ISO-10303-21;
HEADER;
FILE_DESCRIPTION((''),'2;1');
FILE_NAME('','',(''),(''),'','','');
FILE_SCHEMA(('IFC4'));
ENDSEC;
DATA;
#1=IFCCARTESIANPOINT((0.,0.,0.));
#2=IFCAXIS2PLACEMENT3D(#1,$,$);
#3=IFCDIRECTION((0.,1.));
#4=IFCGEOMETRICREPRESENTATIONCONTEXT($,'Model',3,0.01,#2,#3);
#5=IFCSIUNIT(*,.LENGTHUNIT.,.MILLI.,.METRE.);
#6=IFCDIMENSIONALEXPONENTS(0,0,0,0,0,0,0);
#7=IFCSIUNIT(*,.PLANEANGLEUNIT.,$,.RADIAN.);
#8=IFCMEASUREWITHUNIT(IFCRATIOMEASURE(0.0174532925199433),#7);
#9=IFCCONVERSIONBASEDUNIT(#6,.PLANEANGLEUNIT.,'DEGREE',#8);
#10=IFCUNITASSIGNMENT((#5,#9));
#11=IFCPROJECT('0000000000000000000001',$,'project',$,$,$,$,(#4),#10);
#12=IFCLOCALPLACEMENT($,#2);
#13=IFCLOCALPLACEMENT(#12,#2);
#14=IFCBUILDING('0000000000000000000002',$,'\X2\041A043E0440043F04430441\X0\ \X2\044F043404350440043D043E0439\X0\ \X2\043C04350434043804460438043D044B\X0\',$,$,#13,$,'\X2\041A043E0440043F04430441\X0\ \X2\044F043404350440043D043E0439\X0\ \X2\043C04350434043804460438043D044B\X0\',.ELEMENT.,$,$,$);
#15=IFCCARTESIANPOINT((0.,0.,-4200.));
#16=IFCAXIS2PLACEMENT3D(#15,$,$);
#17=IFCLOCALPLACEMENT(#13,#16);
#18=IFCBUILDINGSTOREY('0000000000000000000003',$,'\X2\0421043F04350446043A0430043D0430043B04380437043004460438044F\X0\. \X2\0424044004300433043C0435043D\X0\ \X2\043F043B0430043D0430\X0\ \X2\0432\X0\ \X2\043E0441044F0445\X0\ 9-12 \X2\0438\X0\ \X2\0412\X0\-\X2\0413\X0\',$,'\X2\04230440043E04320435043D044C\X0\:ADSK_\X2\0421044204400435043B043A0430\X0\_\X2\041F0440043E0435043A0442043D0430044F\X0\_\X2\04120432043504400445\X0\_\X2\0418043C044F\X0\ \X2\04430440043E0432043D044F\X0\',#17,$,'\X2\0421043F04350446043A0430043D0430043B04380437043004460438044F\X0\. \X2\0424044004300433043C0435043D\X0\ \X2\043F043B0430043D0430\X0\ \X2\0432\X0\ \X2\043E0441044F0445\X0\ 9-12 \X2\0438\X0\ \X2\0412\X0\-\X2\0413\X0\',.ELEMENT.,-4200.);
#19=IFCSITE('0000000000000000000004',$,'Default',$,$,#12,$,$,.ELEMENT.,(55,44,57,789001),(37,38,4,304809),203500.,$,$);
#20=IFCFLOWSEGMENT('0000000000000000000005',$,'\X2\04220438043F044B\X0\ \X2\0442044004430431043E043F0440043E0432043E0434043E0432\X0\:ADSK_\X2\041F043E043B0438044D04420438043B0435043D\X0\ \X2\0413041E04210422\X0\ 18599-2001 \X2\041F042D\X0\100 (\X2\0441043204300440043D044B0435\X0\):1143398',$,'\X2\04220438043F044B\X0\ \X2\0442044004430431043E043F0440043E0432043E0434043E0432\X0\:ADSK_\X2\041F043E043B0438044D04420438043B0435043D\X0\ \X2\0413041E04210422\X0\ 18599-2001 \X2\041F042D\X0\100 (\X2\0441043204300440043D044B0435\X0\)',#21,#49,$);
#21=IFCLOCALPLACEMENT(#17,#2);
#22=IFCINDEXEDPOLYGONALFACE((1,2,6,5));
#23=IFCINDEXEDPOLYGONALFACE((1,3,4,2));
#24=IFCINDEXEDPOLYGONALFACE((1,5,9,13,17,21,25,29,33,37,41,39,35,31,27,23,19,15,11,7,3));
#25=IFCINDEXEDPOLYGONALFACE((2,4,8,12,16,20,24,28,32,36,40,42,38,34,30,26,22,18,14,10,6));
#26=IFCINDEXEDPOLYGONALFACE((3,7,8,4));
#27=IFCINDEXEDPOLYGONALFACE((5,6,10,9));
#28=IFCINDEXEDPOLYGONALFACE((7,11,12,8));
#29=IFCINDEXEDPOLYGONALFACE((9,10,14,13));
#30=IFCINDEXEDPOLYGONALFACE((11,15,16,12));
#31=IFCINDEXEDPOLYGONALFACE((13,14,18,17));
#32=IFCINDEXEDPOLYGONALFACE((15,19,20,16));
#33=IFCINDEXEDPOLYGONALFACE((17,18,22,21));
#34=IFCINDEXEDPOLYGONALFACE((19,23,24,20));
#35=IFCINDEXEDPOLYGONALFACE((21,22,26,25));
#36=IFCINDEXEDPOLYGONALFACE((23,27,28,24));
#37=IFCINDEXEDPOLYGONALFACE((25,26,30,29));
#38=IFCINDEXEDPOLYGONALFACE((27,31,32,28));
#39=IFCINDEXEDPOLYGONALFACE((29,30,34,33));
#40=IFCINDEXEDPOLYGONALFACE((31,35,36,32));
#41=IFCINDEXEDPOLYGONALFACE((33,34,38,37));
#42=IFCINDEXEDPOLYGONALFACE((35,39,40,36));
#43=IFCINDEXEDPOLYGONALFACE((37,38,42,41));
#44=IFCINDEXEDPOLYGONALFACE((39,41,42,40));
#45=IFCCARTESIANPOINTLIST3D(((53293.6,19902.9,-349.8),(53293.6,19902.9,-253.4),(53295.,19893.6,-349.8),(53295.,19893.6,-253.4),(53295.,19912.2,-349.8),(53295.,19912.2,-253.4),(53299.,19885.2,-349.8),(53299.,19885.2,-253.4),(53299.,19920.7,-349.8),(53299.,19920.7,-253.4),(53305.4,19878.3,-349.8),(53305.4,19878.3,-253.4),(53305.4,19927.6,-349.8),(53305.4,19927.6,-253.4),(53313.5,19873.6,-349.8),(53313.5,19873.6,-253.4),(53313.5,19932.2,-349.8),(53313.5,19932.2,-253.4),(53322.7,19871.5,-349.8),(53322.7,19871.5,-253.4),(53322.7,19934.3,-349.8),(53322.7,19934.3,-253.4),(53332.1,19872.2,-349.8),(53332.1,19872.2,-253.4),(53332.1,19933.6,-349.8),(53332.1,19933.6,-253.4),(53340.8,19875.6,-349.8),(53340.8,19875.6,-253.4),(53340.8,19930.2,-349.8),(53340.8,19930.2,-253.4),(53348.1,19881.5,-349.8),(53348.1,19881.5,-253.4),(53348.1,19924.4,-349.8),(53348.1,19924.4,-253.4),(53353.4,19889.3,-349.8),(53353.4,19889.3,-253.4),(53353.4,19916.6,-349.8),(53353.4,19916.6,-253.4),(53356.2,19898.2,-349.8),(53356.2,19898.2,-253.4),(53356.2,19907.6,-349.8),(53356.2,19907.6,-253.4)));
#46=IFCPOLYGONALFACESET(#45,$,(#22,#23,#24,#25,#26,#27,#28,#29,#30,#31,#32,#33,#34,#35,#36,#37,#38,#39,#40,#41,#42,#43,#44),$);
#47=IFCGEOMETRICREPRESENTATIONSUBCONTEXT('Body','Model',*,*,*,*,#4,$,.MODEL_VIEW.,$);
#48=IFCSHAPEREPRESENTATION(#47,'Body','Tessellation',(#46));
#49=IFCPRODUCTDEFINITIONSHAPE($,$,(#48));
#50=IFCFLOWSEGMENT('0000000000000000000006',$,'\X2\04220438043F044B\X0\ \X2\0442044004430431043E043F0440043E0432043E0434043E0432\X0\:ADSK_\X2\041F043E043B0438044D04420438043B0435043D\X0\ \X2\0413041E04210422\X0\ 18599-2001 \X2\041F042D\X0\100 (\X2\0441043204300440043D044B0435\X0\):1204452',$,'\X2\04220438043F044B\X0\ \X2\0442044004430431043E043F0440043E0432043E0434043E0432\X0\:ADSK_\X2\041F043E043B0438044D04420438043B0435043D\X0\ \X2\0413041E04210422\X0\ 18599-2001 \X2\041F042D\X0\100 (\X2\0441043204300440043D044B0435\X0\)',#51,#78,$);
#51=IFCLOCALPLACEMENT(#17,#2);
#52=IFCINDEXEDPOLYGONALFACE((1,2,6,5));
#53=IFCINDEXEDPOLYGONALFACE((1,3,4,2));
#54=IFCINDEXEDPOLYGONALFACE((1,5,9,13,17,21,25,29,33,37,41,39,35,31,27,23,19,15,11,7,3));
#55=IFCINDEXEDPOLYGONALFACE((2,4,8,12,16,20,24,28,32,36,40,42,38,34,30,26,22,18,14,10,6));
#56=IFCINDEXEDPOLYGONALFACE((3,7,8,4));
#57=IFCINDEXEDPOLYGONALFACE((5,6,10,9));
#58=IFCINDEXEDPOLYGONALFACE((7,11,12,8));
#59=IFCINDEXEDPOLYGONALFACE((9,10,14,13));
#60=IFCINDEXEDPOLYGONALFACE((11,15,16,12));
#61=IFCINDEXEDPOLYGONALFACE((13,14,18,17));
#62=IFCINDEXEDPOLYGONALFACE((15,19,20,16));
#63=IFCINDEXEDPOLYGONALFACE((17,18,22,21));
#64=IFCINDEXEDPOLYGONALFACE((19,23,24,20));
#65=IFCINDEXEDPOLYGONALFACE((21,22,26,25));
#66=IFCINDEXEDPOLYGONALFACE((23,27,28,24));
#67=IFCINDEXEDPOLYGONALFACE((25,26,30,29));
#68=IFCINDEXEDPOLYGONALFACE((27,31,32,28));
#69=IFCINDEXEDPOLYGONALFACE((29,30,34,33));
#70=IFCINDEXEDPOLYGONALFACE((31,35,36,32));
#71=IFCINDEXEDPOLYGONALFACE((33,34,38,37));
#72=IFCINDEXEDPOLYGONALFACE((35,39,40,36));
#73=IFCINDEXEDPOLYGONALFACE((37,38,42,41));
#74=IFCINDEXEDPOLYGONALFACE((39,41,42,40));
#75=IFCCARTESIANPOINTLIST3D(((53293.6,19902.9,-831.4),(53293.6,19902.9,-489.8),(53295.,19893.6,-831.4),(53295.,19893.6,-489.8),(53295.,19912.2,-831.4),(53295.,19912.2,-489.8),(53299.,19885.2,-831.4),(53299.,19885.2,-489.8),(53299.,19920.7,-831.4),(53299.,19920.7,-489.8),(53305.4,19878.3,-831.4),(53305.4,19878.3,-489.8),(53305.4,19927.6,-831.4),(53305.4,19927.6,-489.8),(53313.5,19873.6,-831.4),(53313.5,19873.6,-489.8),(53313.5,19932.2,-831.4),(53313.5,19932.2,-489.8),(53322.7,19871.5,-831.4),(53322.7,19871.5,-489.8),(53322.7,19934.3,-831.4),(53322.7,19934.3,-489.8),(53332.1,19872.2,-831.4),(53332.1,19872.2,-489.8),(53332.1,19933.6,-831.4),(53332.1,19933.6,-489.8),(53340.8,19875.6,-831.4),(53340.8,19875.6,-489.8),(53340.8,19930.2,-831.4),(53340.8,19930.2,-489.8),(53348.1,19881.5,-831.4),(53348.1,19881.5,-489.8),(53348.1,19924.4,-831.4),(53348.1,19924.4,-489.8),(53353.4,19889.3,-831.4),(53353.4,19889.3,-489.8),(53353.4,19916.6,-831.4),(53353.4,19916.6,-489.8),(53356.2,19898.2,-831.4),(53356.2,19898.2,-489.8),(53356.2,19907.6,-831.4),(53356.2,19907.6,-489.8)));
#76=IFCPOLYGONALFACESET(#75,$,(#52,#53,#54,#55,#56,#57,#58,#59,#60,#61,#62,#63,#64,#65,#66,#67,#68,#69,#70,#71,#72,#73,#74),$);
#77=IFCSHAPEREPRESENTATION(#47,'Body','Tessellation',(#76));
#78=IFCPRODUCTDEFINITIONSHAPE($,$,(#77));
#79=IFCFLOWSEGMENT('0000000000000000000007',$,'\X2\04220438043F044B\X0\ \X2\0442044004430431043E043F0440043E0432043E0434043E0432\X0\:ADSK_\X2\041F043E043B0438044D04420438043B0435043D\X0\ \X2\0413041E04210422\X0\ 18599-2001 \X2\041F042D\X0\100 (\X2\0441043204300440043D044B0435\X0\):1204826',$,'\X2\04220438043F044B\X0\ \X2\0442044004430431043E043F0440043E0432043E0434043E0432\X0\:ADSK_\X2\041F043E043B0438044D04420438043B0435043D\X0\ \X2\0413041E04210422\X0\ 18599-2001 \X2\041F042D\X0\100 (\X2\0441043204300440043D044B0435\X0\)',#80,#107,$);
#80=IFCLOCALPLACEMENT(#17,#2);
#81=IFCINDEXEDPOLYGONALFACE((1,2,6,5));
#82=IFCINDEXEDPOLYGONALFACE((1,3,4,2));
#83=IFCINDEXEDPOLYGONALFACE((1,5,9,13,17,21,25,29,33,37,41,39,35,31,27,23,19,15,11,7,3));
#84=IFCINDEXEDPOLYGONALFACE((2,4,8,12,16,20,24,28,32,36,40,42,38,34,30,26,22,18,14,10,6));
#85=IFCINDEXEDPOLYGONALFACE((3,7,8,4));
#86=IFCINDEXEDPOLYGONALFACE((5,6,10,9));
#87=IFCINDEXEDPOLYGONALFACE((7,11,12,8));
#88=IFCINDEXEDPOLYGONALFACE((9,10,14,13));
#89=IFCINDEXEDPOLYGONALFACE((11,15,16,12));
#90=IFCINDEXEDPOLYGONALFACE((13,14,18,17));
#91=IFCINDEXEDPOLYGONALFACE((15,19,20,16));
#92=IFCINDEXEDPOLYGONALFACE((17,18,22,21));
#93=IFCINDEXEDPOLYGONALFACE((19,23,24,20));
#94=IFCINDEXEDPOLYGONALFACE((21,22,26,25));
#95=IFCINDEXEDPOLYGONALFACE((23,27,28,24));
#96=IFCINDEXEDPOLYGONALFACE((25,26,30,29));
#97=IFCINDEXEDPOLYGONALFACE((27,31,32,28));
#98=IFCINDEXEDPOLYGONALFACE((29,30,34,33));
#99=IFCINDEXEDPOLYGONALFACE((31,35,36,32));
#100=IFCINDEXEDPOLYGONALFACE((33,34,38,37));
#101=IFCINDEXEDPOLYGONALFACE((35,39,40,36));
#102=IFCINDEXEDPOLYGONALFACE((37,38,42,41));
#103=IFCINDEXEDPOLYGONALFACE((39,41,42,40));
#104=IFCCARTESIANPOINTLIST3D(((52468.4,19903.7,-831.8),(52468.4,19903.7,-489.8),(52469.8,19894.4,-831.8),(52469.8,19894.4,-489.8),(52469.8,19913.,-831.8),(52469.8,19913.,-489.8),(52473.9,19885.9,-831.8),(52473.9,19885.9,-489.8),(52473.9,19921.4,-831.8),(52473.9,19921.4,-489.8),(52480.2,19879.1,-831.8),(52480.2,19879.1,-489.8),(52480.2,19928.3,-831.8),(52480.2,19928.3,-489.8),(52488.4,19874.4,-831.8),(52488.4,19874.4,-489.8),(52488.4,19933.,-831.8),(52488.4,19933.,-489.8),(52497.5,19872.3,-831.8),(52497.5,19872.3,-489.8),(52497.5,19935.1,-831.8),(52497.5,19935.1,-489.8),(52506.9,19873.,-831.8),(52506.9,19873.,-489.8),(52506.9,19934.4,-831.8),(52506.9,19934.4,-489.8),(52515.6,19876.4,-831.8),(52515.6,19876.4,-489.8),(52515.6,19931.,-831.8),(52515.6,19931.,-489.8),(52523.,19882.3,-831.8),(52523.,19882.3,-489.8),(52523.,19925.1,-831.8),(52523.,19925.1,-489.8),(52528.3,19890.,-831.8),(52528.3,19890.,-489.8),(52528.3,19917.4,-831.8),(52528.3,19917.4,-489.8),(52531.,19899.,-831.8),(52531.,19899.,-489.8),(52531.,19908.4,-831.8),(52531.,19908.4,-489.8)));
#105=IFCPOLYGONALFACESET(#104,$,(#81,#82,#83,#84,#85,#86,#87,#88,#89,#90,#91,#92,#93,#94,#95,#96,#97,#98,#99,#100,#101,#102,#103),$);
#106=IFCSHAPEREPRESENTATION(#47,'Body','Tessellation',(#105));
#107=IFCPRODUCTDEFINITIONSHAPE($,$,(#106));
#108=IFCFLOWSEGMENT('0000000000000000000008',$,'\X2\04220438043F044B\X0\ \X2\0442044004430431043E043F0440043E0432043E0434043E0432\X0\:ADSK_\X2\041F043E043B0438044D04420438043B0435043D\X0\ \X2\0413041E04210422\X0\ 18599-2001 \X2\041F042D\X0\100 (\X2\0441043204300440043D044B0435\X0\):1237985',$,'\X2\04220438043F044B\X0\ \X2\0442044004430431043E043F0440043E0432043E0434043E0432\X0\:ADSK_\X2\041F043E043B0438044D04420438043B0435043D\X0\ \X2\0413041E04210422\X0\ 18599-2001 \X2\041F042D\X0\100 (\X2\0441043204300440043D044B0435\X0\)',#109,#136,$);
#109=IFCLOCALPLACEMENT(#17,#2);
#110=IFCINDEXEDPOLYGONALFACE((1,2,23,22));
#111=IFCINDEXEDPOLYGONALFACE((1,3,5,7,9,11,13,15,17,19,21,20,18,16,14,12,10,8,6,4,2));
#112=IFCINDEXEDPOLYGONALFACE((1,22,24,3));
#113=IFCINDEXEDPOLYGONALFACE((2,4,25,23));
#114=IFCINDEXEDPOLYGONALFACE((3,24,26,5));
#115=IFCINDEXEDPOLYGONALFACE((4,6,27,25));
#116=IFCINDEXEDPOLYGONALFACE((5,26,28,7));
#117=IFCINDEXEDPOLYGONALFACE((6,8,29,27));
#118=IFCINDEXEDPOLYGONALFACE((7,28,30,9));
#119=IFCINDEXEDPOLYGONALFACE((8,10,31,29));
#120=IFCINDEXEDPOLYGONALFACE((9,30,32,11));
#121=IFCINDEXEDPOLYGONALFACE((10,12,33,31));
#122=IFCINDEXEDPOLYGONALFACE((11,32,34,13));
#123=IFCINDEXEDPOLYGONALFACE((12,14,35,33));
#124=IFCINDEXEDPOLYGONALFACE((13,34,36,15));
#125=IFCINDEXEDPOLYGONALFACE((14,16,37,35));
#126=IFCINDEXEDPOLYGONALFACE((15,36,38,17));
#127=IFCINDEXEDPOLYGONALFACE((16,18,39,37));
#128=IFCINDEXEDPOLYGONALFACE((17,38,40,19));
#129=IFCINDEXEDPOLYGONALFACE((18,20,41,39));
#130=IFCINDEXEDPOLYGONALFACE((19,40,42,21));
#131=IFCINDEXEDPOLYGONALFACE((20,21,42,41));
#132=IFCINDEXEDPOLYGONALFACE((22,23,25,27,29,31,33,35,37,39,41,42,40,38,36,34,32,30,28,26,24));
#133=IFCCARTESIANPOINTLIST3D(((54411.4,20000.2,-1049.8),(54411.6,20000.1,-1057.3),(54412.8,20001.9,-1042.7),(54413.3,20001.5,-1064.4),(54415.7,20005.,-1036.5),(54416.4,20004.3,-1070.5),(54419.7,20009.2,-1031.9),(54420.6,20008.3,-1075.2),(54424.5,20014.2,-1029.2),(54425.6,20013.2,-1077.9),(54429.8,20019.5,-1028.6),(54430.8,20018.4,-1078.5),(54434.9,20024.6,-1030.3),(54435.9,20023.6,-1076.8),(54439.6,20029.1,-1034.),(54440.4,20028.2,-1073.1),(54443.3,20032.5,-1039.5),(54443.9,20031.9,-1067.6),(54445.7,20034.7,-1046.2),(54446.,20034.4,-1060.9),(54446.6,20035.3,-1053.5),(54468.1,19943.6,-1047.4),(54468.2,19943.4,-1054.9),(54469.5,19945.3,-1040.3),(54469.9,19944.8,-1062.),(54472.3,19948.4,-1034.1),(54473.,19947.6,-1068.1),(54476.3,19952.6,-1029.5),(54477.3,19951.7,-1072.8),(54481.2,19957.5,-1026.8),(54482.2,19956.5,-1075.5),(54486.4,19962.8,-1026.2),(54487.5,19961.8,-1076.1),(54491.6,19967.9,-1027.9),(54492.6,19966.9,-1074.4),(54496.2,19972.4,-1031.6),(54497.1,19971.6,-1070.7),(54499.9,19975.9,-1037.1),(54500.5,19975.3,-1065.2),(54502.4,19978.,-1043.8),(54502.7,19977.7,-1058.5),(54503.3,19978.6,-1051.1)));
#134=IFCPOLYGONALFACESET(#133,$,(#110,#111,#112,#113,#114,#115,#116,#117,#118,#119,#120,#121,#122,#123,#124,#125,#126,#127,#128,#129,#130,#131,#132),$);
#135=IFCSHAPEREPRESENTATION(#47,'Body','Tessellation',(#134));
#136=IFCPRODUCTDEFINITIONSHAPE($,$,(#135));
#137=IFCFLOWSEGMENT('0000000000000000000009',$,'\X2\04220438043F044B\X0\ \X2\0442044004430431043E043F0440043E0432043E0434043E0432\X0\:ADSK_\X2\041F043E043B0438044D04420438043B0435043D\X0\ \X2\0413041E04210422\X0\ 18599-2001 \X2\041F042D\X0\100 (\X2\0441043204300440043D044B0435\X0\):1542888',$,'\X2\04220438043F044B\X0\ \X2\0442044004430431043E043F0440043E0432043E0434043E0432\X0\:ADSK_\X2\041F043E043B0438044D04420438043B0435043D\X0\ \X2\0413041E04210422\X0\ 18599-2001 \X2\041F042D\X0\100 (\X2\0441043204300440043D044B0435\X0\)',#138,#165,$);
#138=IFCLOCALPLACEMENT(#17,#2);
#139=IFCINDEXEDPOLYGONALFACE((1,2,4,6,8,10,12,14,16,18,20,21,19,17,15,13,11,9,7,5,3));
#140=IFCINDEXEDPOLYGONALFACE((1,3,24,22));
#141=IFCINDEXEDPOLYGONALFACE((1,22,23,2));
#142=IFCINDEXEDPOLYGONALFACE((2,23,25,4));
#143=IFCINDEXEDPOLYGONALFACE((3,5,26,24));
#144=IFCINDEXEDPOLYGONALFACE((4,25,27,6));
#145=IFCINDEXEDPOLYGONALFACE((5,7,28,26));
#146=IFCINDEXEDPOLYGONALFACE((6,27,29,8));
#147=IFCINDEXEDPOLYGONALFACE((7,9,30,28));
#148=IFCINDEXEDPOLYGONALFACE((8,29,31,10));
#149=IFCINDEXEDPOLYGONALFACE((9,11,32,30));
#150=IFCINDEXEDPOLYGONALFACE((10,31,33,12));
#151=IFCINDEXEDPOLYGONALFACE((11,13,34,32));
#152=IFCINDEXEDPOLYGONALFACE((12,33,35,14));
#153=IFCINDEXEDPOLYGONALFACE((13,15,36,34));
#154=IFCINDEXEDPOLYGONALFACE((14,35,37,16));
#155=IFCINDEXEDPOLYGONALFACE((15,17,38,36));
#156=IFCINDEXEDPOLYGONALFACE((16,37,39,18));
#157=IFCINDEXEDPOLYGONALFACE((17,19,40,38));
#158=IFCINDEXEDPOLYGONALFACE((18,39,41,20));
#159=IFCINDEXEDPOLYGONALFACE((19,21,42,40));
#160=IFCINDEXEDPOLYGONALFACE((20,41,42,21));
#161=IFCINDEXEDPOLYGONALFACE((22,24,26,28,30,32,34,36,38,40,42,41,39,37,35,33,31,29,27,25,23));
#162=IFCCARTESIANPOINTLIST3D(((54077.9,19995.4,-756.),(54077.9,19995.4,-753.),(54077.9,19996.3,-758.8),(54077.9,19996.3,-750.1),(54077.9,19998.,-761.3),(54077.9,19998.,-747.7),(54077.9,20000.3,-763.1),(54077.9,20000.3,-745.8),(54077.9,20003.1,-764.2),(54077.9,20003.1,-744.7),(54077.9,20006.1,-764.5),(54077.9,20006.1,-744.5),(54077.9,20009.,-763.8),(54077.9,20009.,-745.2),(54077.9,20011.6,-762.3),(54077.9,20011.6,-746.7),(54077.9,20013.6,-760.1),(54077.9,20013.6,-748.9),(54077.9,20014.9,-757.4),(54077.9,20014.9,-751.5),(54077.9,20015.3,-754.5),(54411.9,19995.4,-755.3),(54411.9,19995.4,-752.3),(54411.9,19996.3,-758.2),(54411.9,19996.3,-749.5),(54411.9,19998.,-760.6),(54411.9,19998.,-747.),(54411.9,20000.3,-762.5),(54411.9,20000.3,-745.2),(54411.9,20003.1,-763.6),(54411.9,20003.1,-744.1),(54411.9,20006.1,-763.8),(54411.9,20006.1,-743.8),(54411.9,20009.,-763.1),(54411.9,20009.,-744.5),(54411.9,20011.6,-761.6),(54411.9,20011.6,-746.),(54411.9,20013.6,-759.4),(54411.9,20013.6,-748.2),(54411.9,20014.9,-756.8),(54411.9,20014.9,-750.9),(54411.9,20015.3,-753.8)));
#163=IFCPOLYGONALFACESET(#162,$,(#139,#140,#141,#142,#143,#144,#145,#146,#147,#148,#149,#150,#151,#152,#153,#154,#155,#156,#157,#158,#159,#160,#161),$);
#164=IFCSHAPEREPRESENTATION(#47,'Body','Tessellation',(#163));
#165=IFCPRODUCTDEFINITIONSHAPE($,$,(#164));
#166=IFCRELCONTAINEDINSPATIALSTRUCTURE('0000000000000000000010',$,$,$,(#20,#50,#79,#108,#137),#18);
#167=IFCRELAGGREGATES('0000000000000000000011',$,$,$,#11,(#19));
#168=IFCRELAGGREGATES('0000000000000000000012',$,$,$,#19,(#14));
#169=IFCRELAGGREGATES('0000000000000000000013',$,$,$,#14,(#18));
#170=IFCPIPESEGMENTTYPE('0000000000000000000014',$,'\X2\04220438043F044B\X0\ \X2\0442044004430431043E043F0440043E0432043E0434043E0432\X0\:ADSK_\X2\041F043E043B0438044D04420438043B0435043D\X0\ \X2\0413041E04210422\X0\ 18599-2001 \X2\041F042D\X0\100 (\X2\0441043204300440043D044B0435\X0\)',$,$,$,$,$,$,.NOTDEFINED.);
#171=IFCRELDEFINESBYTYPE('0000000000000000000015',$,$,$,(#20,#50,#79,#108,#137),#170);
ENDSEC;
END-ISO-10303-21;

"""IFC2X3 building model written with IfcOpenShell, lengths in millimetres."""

from ifc_helpers import new_model, entity, si_unit, converted_unit, direction, frame, frame_2d, origin, origin_2d_with_axis, place, context, subcontext, project, spatial, circle, extrude, type_object, element, save


model = new_model("IFC2X3")

# Units and contexts
model_context = context("Model", 3, precision=0.01, world=origin(), true_north=direction((0.0, 1.0)))
body_context = subcontext(model_context, "Body", "Model", "MODEL_VIEW")
ifc_project = project(units=[si_unit("LENGTHUNIT", "METRE", prefix="MILLI"), converted_unit("PLANEANGLEUNIT", "DEGREE", entity("IfcRatioMeasure", 0.0174532925199433), si_unit("PLANEANGLEUNIT", "RADIAN"), dimensions=[0, 0, 0, 0, 0, 0, 0])], contexts=[model_context])

# Site, building, storey
site_placement = place(None, frame((0.0, 0.0, 0.0)))
site = spatial("IfcSite", under=ifc_project, at=site_placement, Name="Default", CompositionType="ELEMENT", RefLatitude=(55, 44, 57, 789001), RefLongitude=(37, 38, 4, 304809), RefElevation=203500.0)
building_placement = place(site_placement, origin())
building = spatial("IfcBuilding", under=site, at=building_placement, Name="Корпус ядерной медицины", LongName="Корпус ядерной медицины", CompositionType="ELEMENT")
storey_placement = place(building_placement, frame((0.0, 0.0, -4200.0)))
storey = spatial("IfcBuildingStorey", under=building, at=storey_placement, Name="Спецканализация. Фрагмен плана в осях 9-12 и В-Г", ObjectType="Уровень:ADSK_Стрелка_Проектная_Вверх_Имя уровня", LongName="Спецканализация. Фрагмен плана в осях 9-12 и В-Г", CompositionType="ELEMENT", Elevation=-4200.0)

# Flow segments
pipe_segment_type = type_object("IfcPipeSegmentType", Name="Типы трубопроводов:ADSK_Полиэтилен ГОСТ 18599-2001 ПЭ100 (сварные)", PredefinedType="NOTDEFINED")
flow_segment_1_placement = place(storey_placement, frame((53292.0, 19869.8, -349.8)))
element("IfcFlowSegment", 1, at=flow_segment_1_placement, inside=storey, type_object=pipe_segment_type, Name="Типы трубопроводов:ADSK_Полиэтилен ГОСТ 18599-2001 ПЭ100 (сварные):1143398", ObjectType="Типы трубопроводов:ADSK_Полиэтилен ГОСТ 18599-2001 ПЭ100 (сварные)", context=body_context, shape_type="SweptSolid", body=[
    extrude(circle(Radius=31.5, at=origin_2d_with_axis()), frame((33.1, 33.1, 0.0), z_axis=(0.000001, 0.0, 1.0), x_axis=(-1.0, 0.0, 0.000001)), (0.0, 0.0, 1.0), 96.3),
])
flow_segment_2_placement = place(storey_placement, frame((53292.0, 19869.8, -831.4)))
element("IfcFlowSegment", 2, at=flow_segment_2_placement, inside=storey, type_object=pipe_segment_type, Name="Типы трубопроводов:ADSK_Полиэтилен ГОСТ 18599-2001 ПЭ100 (сварные):1204452", ObjectType="Типы трубопроводов:ADSK_Полиэтилен ГОСТ 18599-2001 ПЭ100 (сварные)", context=body_context, shape_type="SweptSolid", body=[
    extrude(circle(Radius=31.5, at=origin_2d_with_axis()), frame((33.1, 33.1, 0.0), z_axis=(0.000002, 0.0, 1.0), x_axis=(-1.0, 0.0, 0.000002)), (0.0, 0.0, 1.0), 341.7),
])
flow_segment_3_placement = place(storey_placement, frame((52466.8, 19870.6, -831.8)))
element("IfcFlowSegment", 3, at=flow_segment_3_placement, inside=storey, type_object=pipe_segment_type, Name="Типы трубопроводов:ADSK_Полиэтилен ГОСТ 18599-2001 ПЭ100 (сварные):1204826", ObjectType="Типы трубопроводов:ADSK_Полиэтилен ГОСТ 18599-2001 ПЭ100 (сварные)", context=body_context, shape_type="SweptSolid", body=[
    extrude(circle(Radius=31.5, at=origin_2d_with_axis()), frame((33.1, 33.1, 0.0), z_axis=(0.000002, 0.0, 1.0), x_axis=(-1.0, 0.0, 0.000002)), (0.0, 0.0, 1.0), 342.0),
])
flow_segment_4_placement = place(storey_placement, frame((54409.7, 19941.7, -1080.1)))
element("IfcFlowSegment", 4, at=flow_segment_4_placement, inside=storey, type_object=pipe_segment_type, Name="Типы трубопроводов:ADSK_Полиэтилен ГОСТ 18599-2001 ПЭ100 (сварные):1237985", ObjectType="Типы трубопроводов:ADSK_Полиэтилен ГОСТ 18599-2001 ПЭ100 (сварные)", context=body_context, shape_type="SweptSolid", body=[
    extrude(circle(Radius=25.0, at=frame_2d((0.0, 0.0), x_axis=(1.0, 0.0))), frame((19.3, 75.9, 26.6), z_axis=(0.706789, -0.706789, 0.029987), x_axis=(0.707107, 0.707107, 0.0)), (0.0, 0.0, 1.0), 80.2),
])
flow_segment_5_placement = place(storey_placement, frame((54077.9, 19993.7, -766.1)))
element("IfcFlowSegment", 5, at=flow_segment_5_placement, inside=storey, type_object=pipe_segment_type, Name="Типы трубопроводов:ADSK_Полиэтилен ГОСТ 18599-2001 ПЭ100 (сварные):1542888", ObjectType="Типы трубопроводов:ADSK_Полиэтилен ГОСТ 18599-2001 ПЭ100 (сварные)", context=body_context, shape_type="SweptSolid", body=[
    extrude(circle(Radius=10.0, at=frame_2d((0.0, 0.0), x_axis=(1.0, 0.0))), frame((0.0, 11.6, 11.6), z_axis=(0.999998, 0.0, 0.002), x_axis=(0.0, 1.0, 0.0)), (0.0, 0.0, 1.0), 334.0),
])

save(model, "model.ifc")
